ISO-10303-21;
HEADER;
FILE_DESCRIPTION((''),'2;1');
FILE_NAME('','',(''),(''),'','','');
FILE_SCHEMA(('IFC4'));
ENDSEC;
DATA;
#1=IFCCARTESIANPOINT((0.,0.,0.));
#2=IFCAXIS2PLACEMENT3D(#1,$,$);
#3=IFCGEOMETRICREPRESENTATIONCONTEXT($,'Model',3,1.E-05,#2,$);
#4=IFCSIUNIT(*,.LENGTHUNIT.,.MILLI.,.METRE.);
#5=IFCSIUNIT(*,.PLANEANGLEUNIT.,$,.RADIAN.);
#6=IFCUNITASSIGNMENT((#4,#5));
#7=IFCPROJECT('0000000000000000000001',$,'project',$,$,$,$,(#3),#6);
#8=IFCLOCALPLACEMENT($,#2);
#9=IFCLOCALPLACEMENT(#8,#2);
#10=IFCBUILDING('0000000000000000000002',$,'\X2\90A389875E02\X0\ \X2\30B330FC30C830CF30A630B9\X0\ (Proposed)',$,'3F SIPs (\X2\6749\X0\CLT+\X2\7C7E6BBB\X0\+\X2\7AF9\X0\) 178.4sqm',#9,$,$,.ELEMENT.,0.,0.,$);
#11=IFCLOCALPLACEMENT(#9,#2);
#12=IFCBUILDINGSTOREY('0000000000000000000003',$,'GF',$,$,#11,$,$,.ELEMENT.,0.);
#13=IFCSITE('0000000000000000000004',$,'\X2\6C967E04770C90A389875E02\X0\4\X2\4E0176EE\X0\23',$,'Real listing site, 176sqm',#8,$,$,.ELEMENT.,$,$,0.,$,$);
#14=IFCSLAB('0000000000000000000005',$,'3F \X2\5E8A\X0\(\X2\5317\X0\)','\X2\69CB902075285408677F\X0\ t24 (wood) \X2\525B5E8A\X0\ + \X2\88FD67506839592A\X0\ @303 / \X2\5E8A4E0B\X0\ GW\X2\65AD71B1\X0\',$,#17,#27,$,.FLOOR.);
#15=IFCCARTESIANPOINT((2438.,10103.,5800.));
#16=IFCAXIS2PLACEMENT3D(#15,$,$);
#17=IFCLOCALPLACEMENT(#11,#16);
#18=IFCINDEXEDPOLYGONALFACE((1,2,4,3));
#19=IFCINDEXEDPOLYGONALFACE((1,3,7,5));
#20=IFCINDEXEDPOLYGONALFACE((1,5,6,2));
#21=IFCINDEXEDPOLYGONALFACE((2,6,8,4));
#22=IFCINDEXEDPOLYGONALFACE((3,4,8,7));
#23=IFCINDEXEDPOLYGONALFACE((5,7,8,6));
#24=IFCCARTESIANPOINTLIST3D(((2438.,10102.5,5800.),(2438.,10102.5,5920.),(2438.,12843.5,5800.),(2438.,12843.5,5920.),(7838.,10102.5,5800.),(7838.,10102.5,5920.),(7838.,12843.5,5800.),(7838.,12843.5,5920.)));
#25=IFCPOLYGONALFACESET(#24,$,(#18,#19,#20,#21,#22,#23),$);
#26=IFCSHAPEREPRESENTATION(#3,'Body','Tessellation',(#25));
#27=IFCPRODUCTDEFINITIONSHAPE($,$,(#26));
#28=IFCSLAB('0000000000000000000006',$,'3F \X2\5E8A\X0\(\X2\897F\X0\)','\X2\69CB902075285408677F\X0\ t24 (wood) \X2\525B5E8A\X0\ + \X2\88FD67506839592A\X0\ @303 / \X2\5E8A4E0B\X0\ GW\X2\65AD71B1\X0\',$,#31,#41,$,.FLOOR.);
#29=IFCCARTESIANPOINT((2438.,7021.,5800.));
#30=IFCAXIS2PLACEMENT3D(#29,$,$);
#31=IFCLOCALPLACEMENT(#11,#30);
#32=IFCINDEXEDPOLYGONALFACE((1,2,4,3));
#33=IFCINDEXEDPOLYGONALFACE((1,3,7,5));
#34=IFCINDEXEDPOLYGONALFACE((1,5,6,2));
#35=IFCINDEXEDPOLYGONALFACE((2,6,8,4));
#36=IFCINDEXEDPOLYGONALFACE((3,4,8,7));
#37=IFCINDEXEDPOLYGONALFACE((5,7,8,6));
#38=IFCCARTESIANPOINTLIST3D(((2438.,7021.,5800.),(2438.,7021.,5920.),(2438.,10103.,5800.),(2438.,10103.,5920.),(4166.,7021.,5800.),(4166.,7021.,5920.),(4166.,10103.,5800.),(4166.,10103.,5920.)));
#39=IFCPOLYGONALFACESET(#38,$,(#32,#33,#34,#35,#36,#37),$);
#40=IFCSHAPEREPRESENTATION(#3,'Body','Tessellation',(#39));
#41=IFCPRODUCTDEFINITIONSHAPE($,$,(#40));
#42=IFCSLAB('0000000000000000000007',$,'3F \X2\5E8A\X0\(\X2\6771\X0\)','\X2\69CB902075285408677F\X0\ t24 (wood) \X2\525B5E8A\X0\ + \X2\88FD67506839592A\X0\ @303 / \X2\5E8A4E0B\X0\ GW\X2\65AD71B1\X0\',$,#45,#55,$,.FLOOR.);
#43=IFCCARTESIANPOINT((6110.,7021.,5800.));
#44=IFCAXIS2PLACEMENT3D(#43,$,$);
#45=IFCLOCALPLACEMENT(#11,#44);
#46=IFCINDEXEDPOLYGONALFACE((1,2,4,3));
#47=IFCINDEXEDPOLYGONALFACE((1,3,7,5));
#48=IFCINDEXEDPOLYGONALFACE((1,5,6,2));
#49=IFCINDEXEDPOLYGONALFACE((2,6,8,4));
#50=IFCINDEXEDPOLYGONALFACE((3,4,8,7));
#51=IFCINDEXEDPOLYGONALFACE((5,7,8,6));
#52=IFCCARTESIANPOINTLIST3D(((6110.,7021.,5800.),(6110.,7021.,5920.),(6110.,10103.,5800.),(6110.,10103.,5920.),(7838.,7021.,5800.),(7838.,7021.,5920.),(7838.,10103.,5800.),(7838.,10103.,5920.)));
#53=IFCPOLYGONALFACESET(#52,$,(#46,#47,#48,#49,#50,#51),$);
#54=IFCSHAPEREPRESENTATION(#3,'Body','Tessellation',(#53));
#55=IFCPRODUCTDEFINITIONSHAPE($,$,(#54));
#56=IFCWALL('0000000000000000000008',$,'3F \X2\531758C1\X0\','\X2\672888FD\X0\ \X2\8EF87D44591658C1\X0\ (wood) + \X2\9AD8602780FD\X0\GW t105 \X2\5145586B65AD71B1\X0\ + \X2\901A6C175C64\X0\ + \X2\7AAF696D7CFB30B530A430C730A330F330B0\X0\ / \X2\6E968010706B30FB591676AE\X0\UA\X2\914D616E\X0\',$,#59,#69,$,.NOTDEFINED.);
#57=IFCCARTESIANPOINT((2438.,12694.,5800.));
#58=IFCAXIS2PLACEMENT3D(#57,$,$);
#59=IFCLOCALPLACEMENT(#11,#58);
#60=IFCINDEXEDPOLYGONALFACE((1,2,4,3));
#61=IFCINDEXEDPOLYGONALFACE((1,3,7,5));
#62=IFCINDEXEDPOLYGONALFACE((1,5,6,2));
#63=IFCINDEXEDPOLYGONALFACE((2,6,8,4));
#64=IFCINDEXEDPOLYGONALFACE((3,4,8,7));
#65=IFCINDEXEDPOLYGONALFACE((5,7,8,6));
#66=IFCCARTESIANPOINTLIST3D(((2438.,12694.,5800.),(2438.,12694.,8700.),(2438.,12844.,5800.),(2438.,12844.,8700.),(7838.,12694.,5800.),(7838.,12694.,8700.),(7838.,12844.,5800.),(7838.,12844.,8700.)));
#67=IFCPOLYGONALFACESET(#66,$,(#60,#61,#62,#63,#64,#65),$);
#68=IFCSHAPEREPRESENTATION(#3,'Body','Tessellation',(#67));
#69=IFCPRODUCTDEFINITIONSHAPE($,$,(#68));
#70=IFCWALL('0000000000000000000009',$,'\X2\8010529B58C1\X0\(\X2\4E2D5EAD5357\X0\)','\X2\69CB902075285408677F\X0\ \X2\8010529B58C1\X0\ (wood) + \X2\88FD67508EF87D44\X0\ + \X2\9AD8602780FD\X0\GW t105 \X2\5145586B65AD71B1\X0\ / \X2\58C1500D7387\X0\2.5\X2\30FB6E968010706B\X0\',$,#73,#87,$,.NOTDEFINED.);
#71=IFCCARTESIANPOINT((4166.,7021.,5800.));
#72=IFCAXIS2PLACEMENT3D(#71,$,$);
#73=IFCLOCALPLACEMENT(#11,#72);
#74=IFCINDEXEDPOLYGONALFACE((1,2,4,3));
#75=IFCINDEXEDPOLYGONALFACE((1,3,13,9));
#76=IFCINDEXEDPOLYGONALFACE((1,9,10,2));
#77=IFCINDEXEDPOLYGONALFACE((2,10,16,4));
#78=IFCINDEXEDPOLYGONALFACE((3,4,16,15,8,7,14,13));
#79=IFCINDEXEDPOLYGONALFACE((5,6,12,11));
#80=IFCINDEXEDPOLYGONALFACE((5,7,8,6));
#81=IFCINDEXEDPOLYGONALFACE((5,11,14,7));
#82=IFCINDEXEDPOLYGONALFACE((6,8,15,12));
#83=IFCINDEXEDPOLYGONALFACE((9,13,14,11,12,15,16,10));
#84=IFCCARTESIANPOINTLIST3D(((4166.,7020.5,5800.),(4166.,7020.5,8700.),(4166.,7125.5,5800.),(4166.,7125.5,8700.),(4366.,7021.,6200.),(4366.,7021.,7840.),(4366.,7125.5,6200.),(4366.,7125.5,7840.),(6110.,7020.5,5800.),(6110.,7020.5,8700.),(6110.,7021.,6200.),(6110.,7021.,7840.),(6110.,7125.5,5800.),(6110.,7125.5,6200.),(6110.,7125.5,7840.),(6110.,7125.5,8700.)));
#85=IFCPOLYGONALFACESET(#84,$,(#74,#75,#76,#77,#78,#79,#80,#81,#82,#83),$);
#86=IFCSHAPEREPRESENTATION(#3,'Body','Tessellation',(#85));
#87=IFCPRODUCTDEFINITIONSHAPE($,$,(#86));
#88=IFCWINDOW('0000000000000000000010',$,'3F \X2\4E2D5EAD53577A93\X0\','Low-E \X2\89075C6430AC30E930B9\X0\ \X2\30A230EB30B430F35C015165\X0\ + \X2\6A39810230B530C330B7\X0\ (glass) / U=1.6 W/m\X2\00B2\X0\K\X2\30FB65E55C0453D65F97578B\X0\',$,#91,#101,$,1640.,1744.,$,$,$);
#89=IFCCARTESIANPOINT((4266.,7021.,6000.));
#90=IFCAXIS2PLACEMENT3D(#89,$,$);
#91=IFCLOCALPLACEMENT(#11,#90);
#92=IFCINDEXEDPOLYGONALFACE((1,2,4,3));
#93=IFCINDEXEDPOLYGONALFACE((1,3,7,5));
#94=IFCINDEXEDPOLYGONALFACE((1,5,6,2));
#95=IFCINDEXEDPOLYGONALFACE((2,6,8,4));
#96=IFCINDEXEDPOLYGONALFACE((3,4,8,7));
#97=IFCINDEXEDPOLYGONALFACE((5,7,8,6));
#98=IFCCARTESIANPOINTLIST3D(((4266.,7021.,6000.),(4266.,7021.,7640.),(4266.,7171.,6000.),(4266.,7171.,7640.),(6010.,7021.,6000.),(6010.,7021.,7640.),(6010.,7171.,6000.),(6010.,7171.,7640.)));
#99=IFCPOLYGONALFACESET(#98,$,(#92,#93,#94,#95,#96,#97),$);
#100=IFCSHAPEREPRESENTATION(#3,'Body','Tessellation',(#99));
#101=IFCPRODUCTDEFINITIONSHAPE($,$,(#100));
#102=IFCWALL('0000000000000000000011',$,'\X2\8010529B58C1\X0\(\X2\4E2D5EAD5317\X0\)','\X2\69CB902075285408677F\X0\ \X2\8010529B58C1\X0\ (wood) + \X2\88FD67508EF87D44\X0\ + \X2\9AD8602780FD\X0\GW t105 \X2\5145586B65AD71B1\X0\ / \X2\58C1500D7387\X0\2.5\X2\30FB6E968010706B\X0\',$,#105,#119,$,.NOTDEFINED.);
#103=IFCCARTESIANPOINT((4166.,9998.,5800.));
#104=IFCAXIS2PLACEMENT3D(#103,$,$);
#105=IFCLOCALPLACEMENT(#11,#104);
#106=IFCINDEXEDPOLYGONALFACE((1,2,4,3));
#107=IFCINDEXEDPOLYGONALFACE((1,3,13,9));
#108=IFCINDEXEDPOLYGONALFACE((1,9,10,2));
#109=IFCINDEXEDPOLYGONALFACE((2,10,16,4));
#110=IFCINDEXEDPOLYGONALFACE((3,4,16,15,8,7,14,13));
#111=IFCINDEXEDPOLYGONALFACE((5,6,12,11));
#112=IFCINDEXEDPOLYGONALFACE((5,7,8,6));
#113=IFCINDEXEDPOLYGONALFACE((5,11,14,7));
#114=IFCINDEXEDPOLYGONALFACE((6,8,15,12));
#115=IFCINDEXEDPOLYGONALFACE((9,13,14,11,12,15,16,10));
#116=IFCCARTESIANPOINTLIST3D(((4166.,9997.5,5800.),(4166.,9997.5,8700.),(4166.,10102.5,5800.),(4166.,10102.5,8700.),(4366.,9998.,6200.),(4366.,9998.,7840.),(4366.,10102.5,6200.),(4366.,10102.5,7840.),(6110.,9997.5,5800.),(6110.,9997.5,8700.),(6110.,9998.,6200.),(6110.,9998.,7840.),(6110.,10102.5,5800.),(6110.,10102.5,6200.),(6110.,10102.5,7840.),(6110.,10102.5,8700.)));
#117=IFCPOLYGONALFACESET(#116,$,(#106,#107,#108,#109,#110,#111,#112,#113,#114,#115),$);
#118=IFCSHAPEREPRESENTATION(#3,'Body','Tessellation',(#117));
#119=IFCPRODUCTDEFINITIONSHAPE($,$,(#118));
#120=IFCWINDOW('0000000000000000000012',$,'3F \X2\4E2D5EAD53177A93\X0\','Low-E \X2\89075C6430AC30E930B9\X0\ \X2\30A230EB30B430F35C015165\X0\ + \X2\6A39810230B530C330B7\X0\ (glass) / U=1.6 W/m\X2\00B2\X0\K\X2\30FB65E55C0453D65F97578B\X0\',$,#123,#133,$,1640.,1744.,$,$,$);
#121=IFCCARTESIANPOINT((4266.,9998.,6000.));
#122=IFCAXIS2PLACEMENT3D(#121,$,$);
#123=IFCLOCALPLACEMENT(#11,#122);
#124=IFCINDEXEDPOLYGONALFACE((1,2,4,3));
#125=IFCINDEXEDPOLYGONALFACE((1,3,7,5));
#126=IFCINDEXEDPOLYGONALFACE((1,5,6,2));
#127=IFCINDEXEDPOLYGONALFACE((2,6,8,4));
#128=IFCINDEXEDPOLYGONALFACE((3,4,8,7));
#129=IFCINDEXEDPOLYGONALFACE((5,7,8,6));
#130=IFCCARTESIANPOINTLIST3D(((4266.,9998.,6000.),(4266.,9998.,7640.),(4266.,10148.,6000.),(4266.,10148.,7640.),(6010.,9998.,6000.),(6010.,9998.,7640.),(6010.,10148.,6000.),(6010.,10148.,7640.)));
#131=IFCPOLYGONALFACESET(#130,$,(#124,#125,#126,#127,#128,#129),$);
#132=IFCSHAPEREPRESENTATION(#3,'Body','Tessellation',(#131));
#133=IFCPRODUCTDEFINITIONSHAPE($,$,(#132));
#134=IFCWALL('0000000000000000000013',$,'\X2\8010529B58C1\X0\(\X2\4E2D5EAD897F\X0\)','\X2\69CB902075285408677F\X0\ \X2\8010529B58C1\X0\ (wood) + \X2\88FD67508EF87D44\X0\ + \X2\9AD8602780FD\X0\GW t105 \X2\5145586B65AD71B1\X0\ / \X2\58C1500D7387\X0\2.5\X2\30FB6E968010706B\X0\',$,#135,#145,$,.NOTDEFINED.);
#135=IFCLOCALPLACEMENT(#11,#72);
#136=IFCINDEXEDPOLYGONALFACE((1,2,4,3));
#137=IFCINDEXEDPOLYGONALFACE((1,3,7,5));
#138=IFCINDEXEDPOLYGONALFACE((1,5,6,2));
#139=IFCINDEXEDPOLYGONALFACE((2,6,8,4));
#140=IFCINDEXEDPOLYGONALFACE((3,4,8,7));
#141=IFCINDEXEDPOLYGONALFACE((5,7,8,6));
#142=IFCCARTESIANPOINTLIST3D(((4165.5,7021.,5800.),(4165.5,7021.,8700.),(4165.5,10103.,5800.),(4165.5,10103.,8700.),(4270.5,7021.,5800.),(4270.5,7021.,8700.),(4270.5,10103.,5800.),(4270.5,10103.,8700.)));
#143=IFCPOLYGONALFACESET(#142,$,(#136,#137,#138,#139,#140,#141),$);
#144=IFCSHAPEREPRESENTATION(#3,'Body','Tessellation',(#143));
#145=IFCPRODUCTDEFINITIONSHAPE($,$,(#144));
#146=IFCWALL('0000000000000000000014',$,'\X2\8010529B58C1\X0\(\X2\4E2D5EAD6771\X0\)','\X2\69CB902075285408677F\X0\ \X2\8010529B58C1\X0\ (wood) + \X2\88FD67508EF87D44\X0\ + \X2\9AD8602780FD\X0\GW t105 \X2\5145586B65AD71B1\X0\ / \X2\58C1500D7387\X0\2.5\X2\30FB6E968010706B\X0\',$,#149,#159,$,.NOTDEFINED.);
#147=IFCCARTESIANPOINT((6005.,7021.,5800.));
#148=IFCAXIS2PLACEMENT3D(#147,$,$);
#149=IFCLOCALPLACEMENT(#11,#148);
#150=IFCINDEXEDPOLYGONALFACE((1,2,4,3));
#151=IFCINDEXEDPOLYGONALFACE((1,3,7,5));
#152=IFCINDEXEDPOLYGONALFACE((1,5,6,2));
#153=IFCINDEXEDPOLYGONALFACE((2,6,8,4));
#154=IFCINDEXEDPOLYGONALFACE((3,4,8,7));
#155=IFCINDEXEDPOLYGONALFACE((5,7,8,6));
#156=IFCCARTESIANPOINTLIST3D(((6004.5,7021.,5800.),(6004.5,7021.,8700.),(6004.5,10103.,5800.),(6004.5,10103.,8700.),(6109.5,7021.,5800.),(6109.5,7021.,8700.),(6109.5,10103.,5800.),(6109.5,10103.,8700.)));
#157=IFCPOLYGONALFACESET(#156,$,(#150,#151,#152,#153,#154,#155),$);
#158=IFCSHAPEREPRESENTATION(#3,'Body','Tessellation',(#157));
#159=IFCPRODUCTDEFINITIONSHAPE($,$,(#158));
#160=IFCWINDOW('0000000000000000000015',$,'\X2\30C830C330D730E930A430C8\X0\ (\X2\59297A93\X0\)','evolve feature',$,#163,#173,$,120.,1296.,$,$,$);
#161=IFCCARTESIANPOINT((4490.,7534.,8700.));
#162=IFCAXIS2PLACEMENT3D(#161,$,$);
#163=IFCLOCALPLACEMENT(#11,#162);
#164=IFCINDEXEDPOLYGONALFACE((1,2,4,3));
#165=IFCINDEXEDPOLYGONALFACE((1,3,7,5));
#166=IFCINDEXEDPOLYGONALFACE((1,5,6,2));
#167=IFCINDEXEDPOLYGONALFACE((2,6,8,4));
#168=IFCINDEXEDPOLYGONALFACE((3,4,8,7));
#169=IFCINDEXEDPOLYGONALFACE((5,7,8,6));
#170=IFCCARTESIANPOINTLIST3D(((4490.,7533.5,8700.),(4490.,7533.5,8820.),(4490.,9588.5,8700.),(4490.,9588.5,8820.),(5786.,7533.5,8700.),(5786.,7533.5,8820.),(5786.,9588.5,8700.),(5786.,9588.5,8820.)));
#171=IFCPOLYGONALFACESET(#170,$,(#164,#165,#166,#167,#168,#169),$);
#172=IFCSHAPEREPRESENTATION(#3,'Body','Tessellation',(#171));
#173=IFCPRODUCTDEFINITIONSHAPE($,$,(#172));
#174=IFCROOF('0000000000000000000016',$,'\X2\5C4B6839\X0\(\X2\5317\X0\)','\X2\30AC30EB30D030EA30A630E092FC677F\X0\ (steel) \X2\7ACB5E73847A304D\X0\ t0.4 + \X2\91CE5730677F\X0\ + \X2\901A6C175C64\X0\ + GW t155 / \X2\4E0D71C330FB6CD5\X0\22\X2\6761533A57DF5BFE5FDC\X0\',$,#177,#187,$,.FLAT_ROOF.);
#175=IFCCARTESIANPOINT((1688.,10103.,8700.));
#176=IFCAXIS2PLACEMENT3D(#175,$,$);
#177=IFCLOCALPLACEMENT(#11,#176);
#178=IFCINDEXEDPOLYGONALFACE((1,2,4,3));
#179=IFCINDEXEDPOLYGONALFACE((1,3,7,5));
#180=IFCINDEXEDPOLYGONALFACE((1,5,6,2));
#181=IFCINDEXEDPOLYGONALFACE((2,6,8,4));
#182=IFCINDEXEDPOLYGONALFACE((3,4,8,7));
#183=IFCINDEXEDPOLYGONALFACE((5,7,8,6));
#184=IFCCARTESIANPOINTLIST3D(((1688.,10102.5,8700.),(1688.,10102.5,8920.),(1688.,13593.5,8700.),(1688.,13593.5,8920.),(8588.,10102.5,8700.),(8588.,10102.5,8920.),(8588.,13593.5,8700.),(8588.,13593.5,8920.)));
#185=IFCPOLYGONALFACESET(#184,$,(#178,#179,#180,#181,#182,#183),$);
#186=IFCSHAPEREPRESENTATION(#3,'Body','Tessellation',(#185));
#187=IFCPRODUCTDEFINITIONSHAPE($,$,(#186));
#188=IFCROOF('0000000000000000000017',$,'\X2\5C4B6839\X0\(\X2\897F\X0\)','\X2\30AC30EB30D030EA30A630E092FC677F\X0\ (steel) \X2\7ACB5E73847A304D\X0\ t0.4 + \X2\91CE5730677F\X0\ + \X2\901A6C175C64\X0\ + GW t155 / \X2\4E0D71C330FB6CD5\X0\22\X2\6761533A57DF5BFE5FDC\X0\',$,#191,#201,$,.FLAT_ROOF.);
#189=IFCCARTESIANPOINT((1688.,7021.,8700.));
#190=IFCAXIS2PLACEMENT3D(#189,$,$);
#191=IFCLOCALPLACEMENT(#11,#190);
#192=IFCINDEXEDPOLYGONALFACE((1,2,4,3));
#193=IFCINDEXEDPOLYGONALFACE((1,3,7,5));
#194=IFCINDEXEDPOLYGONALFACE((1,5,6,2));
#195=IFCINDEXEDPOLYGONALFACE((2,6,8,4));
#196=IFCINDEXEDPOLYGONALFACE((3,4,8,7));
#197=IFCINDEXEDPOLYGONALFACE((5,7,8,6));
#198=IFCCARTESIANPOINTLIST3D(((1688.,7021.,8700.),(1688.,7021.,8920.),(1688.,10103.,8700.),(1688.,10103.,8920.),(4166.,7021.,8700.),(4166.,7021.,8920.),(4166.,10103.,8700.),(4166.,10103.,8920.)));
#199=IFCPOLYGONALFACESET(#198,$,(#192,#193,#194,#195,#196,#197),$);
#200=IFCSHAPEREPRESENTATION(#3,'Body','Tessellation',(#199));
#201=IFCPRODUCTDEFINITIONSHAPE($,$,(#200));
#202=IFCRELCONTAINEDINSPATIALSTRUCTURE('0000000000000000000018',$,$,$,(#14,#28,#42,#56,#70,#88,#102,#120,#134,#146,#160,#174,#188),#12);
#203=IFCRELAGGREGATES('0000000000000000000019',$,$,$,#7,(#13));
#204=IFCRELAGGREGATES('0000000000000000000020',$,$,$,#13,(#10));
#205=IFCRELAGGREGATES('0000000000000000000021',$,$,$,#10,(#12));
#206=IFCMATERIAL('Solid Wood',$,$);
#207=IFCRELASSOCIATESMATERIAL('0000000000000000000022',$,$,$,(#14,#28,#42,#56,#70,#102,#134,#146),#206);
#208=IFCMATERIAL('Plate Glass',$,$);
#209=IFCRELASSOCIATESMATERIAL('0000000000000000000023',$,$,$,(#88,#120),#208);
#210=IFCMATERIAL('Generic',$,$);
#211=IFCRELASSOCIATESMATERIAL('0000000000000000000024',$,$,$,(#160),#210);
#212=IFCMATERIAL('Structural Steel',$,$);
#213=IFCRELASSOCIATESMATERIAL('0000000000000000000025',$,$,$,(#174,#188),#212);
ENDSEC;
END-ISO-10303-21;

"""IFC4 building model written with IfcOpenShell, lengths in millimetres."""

from ifc_helpers import new_model, si_unit, frame, frame_2d, origin, place, context, project, spatial, rectangle, extrude, material, element, fill, save


model = new_model("IFC4")

# Units and contexts
model_context = context("Model", 3, precision=1e-05, world=origin())
ifc_project = project(units=[si_unit("LENGTHUNIT", "METRE", prefix="MILLI"), si_unit("PLANEANGLEUNIT", "RADIAN")], contexts=[model_context])

# Site, building, storey
site_placement = place(None, origin())
site = spatial("IfcSite", under=ifc_project, at=site_placement, Name="沖縄県那覇市4丁目23", ObjectType="Real listing site, 176sqm", CompositionType="ELEMENT", RefElevation=0.0)
building_placement = place(site_placement, origin())
building = spatial("IfcBuilding", under=site, at=building_placement, Name="那覇市 コートハウス (Proposed)", ObjectType="3F SIPs (杉CLT+籾殻+竹) 178.4sqm", CompositionType="ELEMENT", ElevationOfRefHeight=0.0, ElevationOfTerrain=0.0)
storey_placement = place(building_placement, origin())
storey = spatial("IfcBuildingStorey", under=building, at=storey_placement, Name="GF", CompositionType="ELEMENT", Elevation=0.0)

# Slabs
ifc_material_1 = material(Name="Solid Wood")
slab_1_placement = place(storey_placement, frame((2438.0, 10103.0, 5800.0)))
element("IfcSlab", 1, at=slab_1_placement, inside=storey, material=ifc_material_1, Name="3F 床(北)", Description="構造用合板 t24 (wood) 剛床 + 製材根太 @303 / 床下 GW断熱", PredefinedType="FLOOR", context=model_context, shape_type="SweptSolid", body=[
    extrude(rectangle(XDim=5400.0, YDim=2741.0, at=frame_2d((2700.0, 1370.0))), frame((2438.0, 10103.0, 5800.0)), (0.0, 0.0, 1.0), 120.0),
])
slab_2_placement = place(storey_placement, frame((2438.0, 7021.0, 5800.0)))
element("IfcSlab", 2, at=slab_2_placement, inside=storey, material=ifc_material_1, Name="3F 床(西)", Description="構造用合板 t24 (wood) 剛床 + 製材根太 @303 / 床下 GW断熱", PredefinedType="FLOOR", context=model_context, shape_type="SweptSolid", body=[
    extrude(rectangle(XDim=1728.0, YDim=3082.0, at=frame_2d((864.0, 1541.0))), frame((2438.0, 7021.0, 5800.0)), (0.0, 0.0, 1.0), 120.0),
])
slab_3_placement = place(storey_placement, frame((6110.0, 7021.0, 5800.0)))
element("IfcSlab", 3, at=slab_3_placement, inside=storey, material=ifc_material_1, Name="3F 床(東)", Description="構造用合板 t24 (wood) 剛床 + 製材根太 @303 / 床下 GW断熱", PredefinedType="FLOOR", context=model_context, shape_type="SweptSolid", body=[
    extrude(rectangle(XDim=1728.0, YDim=3082.0, at=frame_2d((864.0, 1541.0))), frame((6110.0, 7021.0, 5800.0)), (0.0, 0.0, 1.0), 120.0),
])

# Wall
wall_1_placement = place(storey_placement, frame((2438.0, 12694.0, 5800.0)))
element("IfcWall", 4, at=wall_1_placement, inside=storey, material=ifc_material_1, Name="3F 北壁", Description="木製 軸組外壁 (wood) + 高性能GW t105 充填断熱 + 通気層 + 窯業系サイディング / 準耐火・外皮UA配慮", PredefinedType="NOTDEFINED", context=model_context, shape_type="SweptSolid", body=[
    extrude(rectangle(XDim=5400.0, YDim=150.0, at=frame_2d((2700.0, 75.0))), frame((2438.0, 12694.0, 5800.0)), (0.0, 0.0, 1.0), 2900.0),
])

# Walls, openings, windows
wall_2_placement = place(storey_placement, frame((4166.0, 7021.0, 5800.0)))
wall_2 = element("IfcWall", 5, at=wall_2_placement, inside=storey, material=ifc_material_1, Name="耐力壁(中庭南)", Description="構造用合板 耐力壁 (wood) + 製材軸組 + 高性能GW t105 充填断熱 / 壁倍率2.5・準耐火", PredefinedType="NOTDEFINED", context=model_context, shape_type="SweptSolid", body=[
    extrude(rectangle(XDim=1944.0, YDim=105.0, at=frame_2d((972.0, 52.0))), frame((4166.0, 7021.0, 5800.0)), (0.0, 0.0, 1.0), 2900.0),
])
opening_1_placement = place(storey_placement, frame((4266.0, 7021.0, 6000.0)))
opening_1 = element("IfcOpeningElement", 6, at=opening_1_placement, cuts=wall_2, PredefinedType="NOTDEFINED", context=model_context, shape_type="SweptSolid", body=[
    extrude(rectangle(XDim=1744.0, YDim=150.0, at=frame_2d((872.0, 75.0))), frame((4266.0, 7021.0, 6000.0)), (0.0, 0.0, 1.0), 1640.0),
])
ifc_material_2 = material(Name="Plate Glass")
window_1_placement = place(storey_placement, frame((4266.0, 7021.0, 6000.0)))
window_1 = element("IfcWindow", 7, at=window_1_placement, inside=storey, material=ifc_material_2, Name="3F 中庭南窓", Description="Low-E 複層ガラス アルゴン封入 + 樹脂サッシ (glass) / U=1.6 W/m²K・日射取得型", OverallHeight=1640.0, OverallWidth=1744.0, context=model_context, shape_type="SweptSolid", body=[
    extrude(rectangle(XDim=1744.0, YDim=150.0, at=frame_2d((872.0, 75.0))), frame((4266.0, 7021.0, 6000.0)), (0.0, 0.0, 1.0), 1640.0),
])
fill(opening_1, window_1)
wall_3_placement = place(storey_placement, frame((4166.0, 9998.0, 5800.0)))
wall_3 = element("IfcWall", 8, at=wall_3_placement, inside=storey, material=ifc_material_1, Name="耐力壁(中庭北)", Description="構造用合板 耐力壁 (wood) + 製材軸組 + 高性能GW t105 充填断熱 / 壁倍率2.5・準耐火", PredefinedType="NOTDEFINED", context=model_context, shape_type="SweptSolid", body=[
    extrude(rectangle(XDim=1944.0, YDim=105.0, at=frame_2d((972.0, 52.0))), frame((4166.0, 9998.0, 5800.0)), (0.0, 0.0, 1.0), 2900.0),
])
opening_2_placement = place(storey_placement, frame((4266.0, 9998.0, 6000.0)))
opening_2 = element("IfcOpeningElement", 9, at=opening_2_placement, cuts=wall_3, PredefinedType="NOTDEFINED", context=model_context, shape_type="SweptSolid", body=[
    extrude(rectangle(XDim=1744.0, YDim=150.0, at=frame_2d((872.0, 75.0))), frame((4266.0, 9998.0, 6000.0)), (0.0, 0.0, 1.0), 1640.0),
])
window_2_placement = place(storey_placement, frame((4266.0, 9998.0, 6000.0)))
window_2 = element("IfcWindow", 10, at=window_2_placement, inside=storey, material=ifc_material_2, Name="3F 中庭北窓", Description="Low-E 複層ガラス アルゴン封入 + 樹脂サッシ (glass) / U=1.6 W/m²K・日射取得型", OverallHeight=1640.0, OverallWidth=1744.0, context=model_context, shape_type="SweptSolid", body=[
    extrude(rectangle(XDim=1744.0, YDim=150.0, at=frame_2d((872.0, 75.0))), frame((4266.0, 9998.0, 6000.0)), (0.0, 0.0, 1.0), 1640.0),
])
fill(opening_2, window_2)

# Walls
wall_4_placement = place(storey_placement, frame((4166.0, 7021.0, 5800.0)))
element("IfcWall", 11, at=wall_4_placement, inside=storey, material=ifc_material_1, Name="耐力壁(中庭西)", Description="構造用合板 耐力壁 (wood) + 製材軸組 + 高性能GW t105 充填断熱 / 壁倍率2.5・準耐火", PredefinedType="NOTDEFINED", context=model_context, shape_type="SweptSolid", body=[
    extrude(rectangle(XDim=105.0, YDim=3082.0, at=frame_2d((52.0, 1541.0))), frame((4166.0, 7021.0, 5800.0)), (0.0, 0.0, 1.0), 2900.0),
])
wall_5_placement = place(storey_placement, frame((6005.0, 7021.0, 5800.0)))
element("IfcWall", 12, at=wall_5_placement, inside=storey, material=ifc_material_1, Name="耐力壁(中庭東)", Description="構造用合板 耐力壁 (wood) + 製材軸組 + 高性能GW t105 充填断熱 / 壁倍率2.5・準耐火", PredefinedType="NOTDEFINED", context=model_context, shape_type="SweptSolid", body=[
    extrude(rectangle(XDim=105.0, YDim=3082.0, at=frame_2d((52.0, 1541.0))), frame((6005.0, 7021.0, 5800.0)), (0.0, 0.0, 1.0), 2900.0),
])

# Window
ifc_material_3 = material(Name="Generic")
window_3_placement = place(storey_placement, frame((4490.0, 7534.0, 8700.0)))
element("IfcWindow", 13, at=window_3_placement, inside=storey, material=ifc_material_3, Name="トップライト (天窓)", Description="evolve feature", OverallHeight=120.0, OverallWidth=1296.0, context=model_context, shape_type="SweptSolid", body=[
    extrude(rectangle(XDim=1296.0, YDim=2055.0, at=frame_2d((648.0, 1027.0))), frame((4490.0, 7534.0, 8700.0)), (0.0, 0.0, 1.0), 120.0),
])

# Roofs
ifc_material_4 = material(Name="Structural Steel")
for number, where, name in (
    (14, (1688.0, 10103.0, 8700.0), "屋根(北)"),
):
    element("IfcRoof", number, at=place(storey_placement, frame(where)), inside=storey, material=ifc_material_4, Name=name, Description="ガルバリウム鋼板 (steel) 立平葺き t0.4 + 野地板 + 通気層 + GW t155 / 不燃・法22条区域対応", PredefinedType="FLAT_ROOF", context=model_context, shape_type="SweptSolid", body=[
        extrude(rectangle(XDim=6900.0, YDim=3491.0, at=frame_2d((3450.0, 1745.0))), frame((1688.0, 10103.0, 8700.0)), (0.0, 0.0, 1.0), 220.0),
    ])
roof_1_placement = place(storey_placement, frame((1688.0, 7021.0, 8700.0)))
element("IfcRoof", 15, at=roof_1_placement, inside=storey, material=ifc_material_4, Name="屋根(西)", Description="ガルバリウム鋼板 (steel) 立平葺き t0.4 + 野地板 + 通気層 + GW t155 / 不燃・法22条区域対応", PredefinedType="FLAT_ROOF", context=model_context, shape_type="SweptSolid", body=[
    extrude(rectangle(XDim=2478.0, YDim=3082.0, at=frame_2d((1239.0, 1541.0))), frame((1688.0, 7021.0, 8700.0)), (0.0, 0.0, 1.0), 220.0),
])

save(model, "model.ifc")
